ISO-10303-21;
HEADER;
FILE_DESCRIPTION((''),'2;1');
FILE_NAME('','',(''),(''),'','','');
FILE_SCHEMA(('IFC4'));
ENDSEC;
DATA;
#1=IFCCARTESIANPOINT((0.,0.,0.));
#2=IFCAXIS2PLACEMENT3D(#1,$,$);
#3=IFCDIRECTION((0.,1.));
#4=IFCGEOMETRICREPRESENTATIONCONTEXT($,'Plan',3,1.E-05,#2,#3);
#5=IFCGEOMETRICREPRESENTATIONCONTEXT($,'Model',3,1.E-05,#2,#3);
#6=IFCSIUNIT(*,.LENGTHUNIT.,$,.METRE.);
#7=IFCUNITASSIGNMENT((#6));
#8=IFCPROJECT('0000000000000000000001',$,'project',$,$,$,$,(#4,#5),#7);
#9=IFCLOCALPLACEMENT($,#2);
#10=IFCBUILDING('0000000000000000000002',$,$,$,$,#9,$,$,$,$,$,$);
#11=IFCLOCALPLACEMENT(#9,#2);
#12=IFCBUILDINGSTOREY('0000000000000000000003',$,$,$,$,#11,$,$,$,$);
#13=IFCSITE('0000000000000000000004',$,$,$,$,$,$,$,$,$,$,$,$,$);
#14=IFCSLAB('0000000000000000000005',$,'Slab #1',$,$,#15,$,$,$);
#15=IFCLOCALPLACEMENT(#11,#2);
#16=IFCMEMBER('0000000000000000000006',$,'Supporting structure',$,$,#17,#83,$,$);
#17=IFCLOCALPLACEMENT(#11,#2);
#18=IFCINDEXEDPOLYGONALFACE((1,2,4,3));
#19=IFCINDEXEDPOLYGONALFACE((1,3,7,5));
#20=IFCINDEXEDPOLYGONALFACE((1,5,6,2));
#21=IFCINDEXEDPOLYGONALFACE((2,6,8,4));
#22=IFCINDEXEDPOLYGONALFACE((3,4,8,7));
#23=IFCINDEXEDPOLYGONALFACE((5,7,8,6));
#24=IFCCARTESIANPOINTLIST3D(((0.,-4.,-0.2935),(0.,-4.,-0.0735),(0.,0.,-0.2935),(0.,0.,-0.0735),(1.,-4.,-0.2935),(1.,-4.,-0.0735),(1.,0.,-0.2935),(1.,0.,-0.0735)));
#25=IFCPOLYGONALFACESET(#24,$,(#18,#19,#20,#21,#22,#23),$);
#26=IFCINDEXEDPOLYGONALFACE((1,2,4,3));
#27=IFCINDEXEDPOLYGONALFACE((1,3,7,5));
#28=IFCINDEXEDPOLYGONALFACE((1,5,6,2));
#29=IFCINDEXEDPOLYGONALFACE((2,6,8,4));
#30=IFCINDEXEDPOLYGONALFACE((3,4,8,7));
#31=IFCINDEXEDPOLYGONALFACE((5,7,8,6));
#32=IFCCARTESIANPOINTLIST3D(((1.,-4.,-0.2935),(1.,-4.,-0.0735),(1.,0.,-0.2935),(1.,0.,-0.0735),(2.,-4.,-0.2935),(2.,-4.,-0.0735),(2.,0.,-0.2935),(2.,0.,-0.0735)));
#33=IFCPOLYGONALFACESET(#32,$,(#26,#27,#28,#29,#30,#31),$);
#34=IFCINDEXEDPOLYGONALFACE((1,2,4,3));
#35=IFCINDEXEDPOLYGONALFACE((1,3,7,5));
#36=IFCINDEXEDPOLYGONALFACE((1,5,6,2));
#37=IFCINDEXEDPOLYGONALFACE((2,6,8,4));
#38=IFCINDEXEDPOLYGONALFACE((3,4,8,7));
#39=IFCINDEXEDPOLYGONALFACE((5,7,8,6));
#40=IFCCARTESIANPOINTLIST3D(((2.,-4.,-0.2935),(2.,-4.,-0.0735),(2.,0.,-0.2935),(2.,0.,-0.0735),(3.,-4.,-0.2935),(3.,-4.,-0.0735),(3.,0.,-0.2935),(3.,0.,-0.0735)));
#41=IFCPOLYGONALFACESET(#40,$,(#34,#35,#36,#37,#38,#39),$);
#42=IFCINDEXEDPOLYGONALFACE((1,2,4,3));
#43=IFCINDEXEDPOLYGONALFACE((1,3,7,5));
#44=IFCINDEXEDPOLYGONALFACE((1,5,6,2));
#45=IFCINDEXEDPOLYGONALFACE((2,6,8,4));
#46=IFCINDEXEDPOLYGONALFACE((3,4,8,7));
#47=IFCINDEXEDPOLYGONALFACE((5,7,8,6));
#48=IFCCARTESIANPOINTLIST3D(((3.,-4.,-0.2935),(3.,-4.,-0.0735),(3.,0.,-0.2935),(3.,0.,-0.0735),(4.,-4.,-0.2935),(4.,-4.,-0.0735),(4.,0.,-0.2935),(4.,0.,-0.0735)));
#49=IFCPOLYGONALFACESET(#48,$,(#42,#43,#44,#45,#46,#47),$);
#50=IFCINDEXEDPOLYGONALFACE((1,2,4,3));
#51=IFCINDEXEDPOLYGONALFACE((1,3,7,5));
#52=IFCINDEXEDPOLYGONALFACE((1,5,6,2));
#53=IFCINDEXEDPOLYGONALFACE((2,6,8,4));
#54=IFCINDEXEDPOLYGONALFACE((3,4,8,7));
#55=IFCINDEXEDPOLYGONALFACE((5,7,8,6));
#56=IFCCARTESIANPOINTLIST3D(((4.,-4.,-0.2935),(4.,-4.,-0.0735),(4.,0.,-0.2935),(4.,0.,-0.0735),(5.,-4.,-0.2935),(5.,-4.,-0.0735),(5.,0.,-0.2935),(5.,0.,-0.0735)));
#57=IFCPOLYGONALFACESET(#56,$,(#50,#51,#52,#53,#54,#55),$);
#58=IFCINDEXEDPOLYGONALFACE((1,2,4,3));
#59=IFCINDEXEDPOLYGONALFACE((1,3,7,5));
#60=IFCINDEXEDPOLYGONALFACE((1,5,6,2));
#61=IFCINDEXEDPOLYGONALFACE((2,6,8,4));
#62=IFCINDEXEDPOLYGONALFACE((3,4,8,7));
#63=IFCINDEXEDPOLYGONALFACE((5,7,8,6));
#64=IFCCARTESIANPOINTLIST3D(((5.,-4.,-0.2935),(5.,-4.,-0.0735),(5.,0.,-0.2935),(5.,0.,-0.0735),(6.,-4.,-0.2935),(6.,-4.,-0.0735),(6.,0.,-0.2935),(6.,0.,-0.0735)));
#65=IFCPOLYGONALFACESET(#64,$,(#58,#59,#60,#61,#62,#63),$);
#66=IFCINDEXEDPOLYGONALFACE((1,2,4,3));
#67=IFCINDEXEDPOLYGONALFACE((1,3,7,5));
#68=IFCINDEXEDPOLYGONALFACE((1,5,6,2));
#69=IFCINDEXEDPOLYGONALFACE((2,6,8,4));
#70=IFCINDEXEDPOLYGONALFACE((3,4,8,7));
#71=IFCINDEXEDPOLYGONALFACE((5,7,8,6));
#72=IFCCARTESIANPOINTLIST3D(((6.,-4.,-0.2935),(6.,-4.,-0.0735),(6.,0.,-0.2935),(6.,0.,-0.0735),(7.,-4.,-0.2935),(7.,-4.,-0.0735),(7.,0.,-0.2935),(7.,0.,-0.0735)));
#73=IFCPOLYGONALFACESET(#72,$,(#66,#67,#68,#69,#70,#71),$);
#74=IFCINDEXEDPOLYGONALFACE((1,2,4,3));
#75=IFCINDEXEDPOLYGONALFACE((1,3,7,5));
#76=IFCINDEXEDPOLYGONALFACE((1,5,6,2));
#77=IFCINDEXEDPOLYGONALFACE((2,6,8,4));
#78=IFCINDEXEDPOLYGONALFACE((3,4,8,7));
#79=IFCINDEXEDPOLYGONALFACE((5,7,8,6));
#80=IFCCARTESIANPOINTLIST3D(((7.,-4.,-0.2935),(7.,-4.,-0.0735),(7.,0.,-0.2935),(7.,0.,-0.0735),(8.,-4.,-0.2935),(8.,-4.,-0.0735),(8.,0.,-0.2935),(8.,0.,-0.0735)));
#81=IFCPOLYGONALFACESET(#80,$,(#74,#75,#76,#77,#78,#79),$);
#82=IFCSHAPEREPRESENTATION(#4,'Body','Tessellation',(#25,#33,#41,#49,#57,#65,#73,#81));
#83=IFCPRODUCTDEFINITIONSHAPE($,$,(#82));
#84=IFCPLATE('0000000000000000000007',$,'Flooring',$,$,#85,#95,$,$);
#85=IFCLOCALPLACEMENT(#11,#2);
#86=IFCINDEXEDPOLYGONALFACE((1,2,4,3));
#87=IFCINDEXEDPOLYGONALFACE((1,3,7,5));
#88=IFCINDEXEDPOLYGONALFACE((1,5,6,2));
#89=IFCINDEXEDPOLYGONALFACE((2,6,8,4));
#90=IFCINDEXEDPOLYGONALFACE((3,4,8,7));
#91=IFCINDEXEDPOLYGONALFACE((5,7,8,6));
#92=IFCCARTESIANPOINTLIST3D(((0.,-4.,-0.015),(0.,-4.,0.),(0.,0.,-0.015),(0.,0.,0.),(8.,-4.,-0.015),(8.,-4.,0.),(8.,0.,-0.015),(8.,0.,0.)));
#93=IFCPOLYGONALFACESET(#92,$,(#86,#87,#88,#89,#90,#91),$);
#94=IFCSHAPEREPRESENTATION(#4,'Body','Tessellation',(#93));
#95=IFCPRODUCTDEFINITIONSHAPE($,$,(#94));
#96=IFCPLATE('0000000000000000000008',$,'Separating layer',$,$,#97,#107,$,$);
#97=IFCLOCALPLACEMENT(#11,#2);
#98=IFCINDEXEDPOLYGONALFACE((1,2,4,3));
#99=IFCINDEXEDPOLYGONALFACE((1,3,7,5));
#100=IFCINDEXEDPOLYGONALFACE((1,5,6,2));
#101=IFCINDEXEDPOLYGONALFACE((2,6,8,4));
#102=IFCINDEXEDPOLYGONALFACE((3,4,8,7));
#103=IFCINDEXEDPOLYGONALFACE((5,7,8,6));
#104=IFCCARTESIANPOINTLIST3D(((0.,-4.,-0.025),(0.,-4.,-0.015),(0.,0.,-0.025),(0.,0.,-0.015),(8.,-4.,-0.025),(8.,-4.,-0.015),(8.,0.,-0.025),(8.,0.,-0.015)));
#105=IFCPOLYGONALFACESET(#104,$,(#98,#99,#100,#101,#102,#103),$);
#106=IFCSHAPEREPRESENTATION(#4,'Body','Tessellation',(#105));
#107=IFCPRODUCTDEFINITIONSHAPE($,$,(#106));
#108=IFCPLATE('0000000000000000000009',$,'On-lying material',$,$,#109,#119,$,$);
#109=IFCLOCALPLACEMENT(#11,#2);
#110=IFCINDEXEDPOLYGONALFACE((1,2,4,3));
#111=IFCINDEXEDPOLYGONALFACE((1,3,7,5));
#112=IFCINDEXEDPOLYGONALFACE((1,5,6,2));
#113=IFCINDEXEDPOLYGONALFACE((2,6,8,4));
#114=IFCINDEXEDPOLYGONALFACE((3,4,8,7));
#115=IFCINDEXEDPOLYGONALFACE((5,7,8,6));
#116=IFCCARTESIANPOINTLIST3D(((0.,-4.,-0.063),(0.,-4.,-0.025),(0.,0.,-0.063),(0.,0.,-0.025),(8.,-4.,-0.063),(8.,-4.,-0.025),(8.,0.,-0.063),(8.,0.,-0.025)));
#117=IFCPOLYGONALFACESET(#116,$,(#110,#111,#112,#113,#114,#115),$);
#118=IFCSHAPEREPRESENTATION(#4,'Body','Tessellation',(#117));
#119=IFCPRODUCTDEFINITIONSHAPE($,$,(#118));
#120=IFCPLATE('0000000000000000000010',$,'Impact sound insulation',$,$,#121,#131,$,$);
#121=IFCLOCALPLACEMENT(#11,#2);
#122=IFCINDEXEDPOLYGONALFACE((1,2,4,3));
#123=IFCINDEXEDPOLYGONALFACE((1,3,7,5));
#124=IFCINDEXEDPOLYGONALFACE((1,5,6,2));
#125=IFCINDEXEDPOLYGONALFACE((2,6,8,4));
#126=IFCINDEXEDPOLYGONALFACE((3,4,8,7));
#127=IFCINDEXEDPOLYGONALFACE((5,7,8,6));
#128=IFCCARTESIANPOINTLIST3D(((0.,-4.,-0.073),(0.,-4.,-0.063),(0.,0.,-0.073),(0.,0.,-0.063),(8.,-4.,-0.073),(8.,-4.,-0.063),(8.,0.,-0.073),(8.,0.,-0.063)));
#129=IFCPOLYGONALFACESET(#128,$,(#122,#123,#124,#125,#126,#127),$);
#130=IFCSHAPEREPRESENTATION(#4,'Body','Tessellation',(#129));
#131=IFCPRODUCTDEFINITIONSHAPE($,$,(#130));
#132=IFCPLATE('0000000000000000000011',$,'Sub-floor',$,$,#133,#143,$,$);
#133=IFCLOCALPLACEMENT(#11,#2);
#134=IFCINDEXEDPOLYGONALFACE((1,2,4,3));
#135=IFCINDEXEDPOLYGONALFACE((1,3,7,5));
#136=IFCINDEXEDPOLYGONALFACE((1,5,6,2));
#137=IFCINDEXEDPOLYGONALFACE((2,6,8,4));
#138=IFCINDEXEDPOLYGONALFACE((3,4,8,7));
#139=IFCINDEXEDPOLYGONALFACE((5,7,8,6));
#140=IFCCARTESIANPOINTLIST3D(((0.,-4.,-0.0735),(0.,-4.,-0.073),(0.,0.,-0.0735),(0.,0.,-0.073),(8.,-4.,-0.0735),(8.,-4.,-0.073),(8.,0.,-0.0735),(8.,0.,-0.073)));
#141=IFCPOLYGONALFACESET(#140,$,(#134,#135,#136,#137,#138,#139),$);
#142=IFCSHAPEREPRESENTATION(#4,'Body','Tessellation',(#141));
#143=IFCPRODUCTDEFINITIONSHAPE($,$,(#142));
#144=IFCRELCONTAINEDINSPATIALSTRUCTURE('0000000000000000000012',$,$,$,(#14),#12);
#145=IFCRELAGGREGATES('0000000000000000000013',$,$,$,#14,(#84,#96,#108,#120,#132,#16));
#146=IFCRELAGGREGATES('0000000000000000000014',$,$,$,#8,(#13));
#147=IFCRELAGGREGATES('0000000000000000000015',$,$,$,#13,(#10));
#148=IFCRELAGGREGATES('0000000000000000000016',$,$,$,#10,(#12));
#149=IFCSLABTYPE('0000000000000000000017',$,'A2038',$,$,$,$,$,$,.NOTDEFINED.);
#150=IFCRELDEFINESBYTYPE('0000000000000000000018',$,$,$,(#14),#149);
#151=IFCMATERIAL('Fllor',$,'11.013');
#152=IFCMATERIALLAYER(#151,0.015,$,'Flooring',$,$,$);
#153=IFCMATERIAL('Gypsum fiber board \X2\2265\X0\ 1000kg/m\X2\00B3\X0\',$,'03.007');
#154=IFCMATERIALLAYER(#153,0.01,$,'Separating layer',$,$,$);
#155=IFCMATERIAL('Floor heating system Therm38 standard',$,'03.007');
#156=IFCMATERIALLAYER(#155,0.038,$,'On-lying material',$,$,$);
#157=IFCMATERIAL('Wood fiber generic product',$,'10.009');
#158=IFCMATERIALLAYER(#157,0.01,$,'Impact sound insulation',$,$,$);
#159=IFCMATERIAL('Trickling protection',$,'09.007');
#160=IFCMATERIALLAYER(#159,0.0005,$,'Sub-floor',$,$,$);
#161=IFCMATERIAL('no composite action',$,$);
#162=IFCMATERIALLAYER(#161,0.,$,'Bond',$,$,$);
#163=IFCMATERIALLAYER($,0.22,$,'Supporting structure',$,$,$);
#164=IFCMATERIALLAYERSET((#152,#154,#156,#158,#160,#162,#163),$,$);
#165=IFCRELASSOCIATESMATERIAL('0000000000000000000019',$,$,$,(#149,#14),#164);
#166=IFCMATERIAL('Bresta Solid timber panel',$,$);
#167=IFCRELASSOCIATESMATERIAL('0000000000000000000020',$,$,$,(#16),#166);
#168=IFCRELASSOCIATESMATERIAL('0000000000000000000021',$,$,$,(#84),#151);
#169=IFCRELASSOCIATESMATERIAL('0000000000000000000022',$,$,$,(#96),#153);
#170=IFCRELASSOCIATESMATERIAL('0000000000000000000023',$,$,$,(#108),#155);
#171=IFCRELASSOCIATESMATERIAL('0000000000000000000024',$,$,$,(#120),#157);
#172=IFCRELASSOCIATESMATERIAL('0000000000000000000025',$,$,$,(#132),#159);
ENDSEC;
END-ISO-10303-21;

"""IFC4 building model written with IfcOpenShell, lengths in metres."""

from ifc_helpers import new_model, si_unit, direction, frame, frame_2d, origin, origin_with_axes, place, context, project, spatial, rectangle, extrude, material, layer, layer_set, type_object, element, aggregate, save


model = new_model("IFC4")

# Units and contexts
plan_context = context("Plan", 3, precision=1e-05, world=origin(), true_north=direction((0.0, 1.0)))
model_context = context("Model", 3, precision=1e-05, world=origin(), true_north=direction((0.0, 1.0)))
ifc_project = project(units=[si_unit("LENGTHUNIT", "METRE")], contexts=[plan_context, model_context])

# Site, building, storey
site = spatial("IfcSite", under=ifc_project)
building_placement = place(None, origin())
building = spatial("IfcBuilding", under=site, at=building_placement)
storey_placement = place(building_placement, origin())
storey = spatial("IfcBuildingStorey", under=building, at=storey_placement)

# Slab, member, plates
ifc_material_1 = material(Name="Fllor", Category="11.013")
ifc_layer_1 = layer(ifc_material_1, 0.015, Name="Flooring")
ifc_material_2 = material(Name="Gypsum fiber board ≥ 1000kg/m³", Category="03.007")
ifc_layer_2 = layer(ifc_material_2, 0.01, Name="Separating layer")
ifc_material_3 = material(Name="Floor heating system Therm38 standard", Category="03.007")
ifc_layer_3 = layer(ifc_material_3, 0.038, Name="On-lying material")
ifc_material_4 = material(Name="Wood fiber generic product", Category="10.009")
ifc_layer_4 = layer(ifc_material_4, 0.01, Name="Impact sound insulation")
ifc_material_5 = material(Name="Trickling protection", Category="09.007")
ifc_layer_5 = layer(ifc_material_5, 0.0005, Name="Sub-floor")
ifc_material_6 = material(Name="no composite action")
ifc_layer_6 = layer(ifc_material_6, 0.0, Name="Bond")
ifc_layer_7 = layer(None, 0.22, Name="Supporting structure")
ifc_layer_set = layer_set([ifc_layer_1, ifc_layer_2, ifc_layer_3, ifc_layer_4, ifc_layer_5, ifc_layer_6, ifc_layer_7])
slab_type = type_object("IfcSlabType", Name="A2038", PredefinedType="NOTDEFINED", material=ifc_layer_set)
slab_placement = place(None, frame((0.0, 0.0, 0.0), z_axis=(0.0, 0.0, -1.0), x_axis=(1.0, 0.0, 0.0)))
slab = element("IfcSlab", 1, at=slab_placement, inside=storey, type_object=slab_type, material=ifc_layer_set, Name="Slab #1")
ifc_material_7 = material(Name="Bresta Solid timber panel")
member_placement = place(slab_placement, origin())
member = element("IfcMember", 2, at=member_placement, material=ifc_material_7, Name="Supporting structure", context=plan_context, shape_type="SweptSolid", body=[
    extrude(rectangle(XDim=1.0, YDim=0.22, at=frame_2d((0.5, 0.11), x_axis=(1.0, 0.0))), frame((0.0, 4.0, 0.0735), z_axis=(0.0, -1.0, 0.0), x_axis=(1.0, 0.0, 0.0)), (0.0, 0.0, 1.0), 4.0),
    extrude(rectangle(XDim=1.0, YDim=0.22, at=frame_2d((0.5, 0.11), x_axis=(1.0, 0.0))), frame((1.0, 4.0, 0.0735), z_axis=(0.0, -1.0, 0.0), x_axis=(1.0, 0.0, 0.0)), (0.0, 0.0, 1.0), 4.0),
    extrude(rectangle(XDim=1.0, YDim=0.22, at=frame_2d((0.5, 0.11), x_axis=(1.0, 0.0))), frame((2.0, 4.0, 0.0735), z_axis=(0.0, -1.0, 0.0), x_axis=(1.0, 0.0, 0.0)), (0.0, 0.0, 1.0), 4.0),
    extrude(rectangle(XDim=1.0, YDim=0.22, at=frame_2d((0.5, 0.11), x_axis=(1.0, 0.0))), frame((3.0, 4.0, 0.0735), z_axis=(0.0, -1.0, 0.0), x_axis=(1.0, 0.0, 0.0)), (0.0, 0.0, 1.0), 4.0),
    extrude(rectangle(XDim=1.0, YDim=0.22, at=frame_2d((0.5, 0.11), x_axis=(1.0, 0.0))), frame((4.0, 4.0, 0.0735), z_axis=(0.0, -1.0, 0.0), x_axis=(1.0, 0.0, 0.0)), (0.0, 0.0, 1.0), 4.0),
    extrude(rectangle(XDim=1.0, YDim=0.22, at=frame_2d((0.5, 0.11), x_axis=(1.0, 0.0))), frame((5.0, 4.0, 0.0735), z_axis=(0.0, -1.0, 0.0), x_axis=(1.0, 0.0, 0.0)), (0.0, 0.0, 1.0), 4.0),
    extrude(rectangle(XDim=1.0, YDim=0.22, at=frame_2d((0.5, 0.11), x_axis=(1.0, 0.0))), frame((6.0, 4.0, 0.0735), z_axis=(0.0, -1.0, 0.0), x_axis=(1.0, 0.0, 0.0)), (0.0, 0.0, 1.0), 4.0),
    extrude(rectangle(XDim=1.0, YDim=0.22, at=frame_2d((0.5, 0.11), x_axis=(1.0, 0.0))), frame((7.0, 4.0, 0.0735), z_axis=(0.0, -1.0, 0.0), x_axis=(1.0, 0.0, 0.0)), (0.0, 0.0, 1.0), 4.0),
])
plate_1_placement = place(slab_placement, origin())
plate_1 = element("IfcPlate", 3, at=plate_1_placement, material=ifc_material_1, Name="Flooring", context=plan_context, shape_type="SweptSolid", body=[
    extrude(rectangle(XDim=8.0, YDim=4.0, at=frame_2d((4.0, 2.0), x_axis=(1.0, 0.0))), origin_with_axes(), (0.0, 0.0, 1.0), 0.015),
])
plate_2_placement = place(slab_placement, origin())
plate_2 = element("IfcPlate", 4, at=plate_2_placement, material=ifc_material_2, Name="Separating layer", context=plan_context, shape_type="SweptSolid", body=[
    extrude(rectangle(XDim=8.0, YDim=4.0, at=frame_2d((4.0, 2.0), x_axis=(1.0, 0.0))), frame((0.0, 0.0, 0.015), z_axis=(0.0, 0.0, 1.0), x_axis=(1.0, 0.0, 0.0)), (0.0, 0.0, 1.0), 0.01),
])
plate_3_placement = place(slab_placement, origin())
plate_3 = element("IfcPlate", 5, at=plate_3_placement, material=ifc_material_3, Name="On-lying material", context=plan_context, shape_type="SweptSolid", body=[
    extrude(rectangle(XDim=8.0, YDim=4.0, at=frame_2d((4.0, 2.0), x_axis=(1.0, 0.0))), frame((0.0, 0.0, 0.025), z_axis=(0.0, 0.0, 1.0), x_axis=(1.0, 0.0, 0.0)), (0.0, 0.0, 1.0), 0.038),
])
plate_4_placement = place(slab_placement, origin())
plate_4 = element("IfcPlate", 6, at=plate_4_placement, material=ifc_material_4, Name="Impact sound insulation", context=plan_context, shape_type="SweptSolid", body=[
    extrude(rectangle(XDim=8.0, YDim=4.0, at=frame_2d((4.0, 2.0), x_axis=(1.0, 0.0))), frame((0.0, 0.0, 0.063), z_axis=(0.0, 0.0, 1.0), x_axis=(1.0, 0.0, 0.0)), (0.0, 0.0, 1.0), 0.01),
])
plate_5_placement = place(slab_placement, origin())
plate_5 = element("IfcPlate", 7, at=plate_5_placement, material=ifc_material_5, Name="Sub-floor", context=plan_context, shape_type="SweptSolid", body=[
    extrude(rectangle(XDim=8.0, YDim=4.0, at=frame_2d((4.0, 2.0), x_axis=(1.0, 0.0))), frame((0.0, 0.0, 0.073), z_axis=(0.0, 0.0, 1.0), x_axis=(1.0, 0.0, 0.0)), (0.0, 0.0, 1.0), 0.0005),
])
aggregate(slab, [plate_1, plate_2, plate_3, plate_4, plate_5, member])

save(model, "model.ifc")
